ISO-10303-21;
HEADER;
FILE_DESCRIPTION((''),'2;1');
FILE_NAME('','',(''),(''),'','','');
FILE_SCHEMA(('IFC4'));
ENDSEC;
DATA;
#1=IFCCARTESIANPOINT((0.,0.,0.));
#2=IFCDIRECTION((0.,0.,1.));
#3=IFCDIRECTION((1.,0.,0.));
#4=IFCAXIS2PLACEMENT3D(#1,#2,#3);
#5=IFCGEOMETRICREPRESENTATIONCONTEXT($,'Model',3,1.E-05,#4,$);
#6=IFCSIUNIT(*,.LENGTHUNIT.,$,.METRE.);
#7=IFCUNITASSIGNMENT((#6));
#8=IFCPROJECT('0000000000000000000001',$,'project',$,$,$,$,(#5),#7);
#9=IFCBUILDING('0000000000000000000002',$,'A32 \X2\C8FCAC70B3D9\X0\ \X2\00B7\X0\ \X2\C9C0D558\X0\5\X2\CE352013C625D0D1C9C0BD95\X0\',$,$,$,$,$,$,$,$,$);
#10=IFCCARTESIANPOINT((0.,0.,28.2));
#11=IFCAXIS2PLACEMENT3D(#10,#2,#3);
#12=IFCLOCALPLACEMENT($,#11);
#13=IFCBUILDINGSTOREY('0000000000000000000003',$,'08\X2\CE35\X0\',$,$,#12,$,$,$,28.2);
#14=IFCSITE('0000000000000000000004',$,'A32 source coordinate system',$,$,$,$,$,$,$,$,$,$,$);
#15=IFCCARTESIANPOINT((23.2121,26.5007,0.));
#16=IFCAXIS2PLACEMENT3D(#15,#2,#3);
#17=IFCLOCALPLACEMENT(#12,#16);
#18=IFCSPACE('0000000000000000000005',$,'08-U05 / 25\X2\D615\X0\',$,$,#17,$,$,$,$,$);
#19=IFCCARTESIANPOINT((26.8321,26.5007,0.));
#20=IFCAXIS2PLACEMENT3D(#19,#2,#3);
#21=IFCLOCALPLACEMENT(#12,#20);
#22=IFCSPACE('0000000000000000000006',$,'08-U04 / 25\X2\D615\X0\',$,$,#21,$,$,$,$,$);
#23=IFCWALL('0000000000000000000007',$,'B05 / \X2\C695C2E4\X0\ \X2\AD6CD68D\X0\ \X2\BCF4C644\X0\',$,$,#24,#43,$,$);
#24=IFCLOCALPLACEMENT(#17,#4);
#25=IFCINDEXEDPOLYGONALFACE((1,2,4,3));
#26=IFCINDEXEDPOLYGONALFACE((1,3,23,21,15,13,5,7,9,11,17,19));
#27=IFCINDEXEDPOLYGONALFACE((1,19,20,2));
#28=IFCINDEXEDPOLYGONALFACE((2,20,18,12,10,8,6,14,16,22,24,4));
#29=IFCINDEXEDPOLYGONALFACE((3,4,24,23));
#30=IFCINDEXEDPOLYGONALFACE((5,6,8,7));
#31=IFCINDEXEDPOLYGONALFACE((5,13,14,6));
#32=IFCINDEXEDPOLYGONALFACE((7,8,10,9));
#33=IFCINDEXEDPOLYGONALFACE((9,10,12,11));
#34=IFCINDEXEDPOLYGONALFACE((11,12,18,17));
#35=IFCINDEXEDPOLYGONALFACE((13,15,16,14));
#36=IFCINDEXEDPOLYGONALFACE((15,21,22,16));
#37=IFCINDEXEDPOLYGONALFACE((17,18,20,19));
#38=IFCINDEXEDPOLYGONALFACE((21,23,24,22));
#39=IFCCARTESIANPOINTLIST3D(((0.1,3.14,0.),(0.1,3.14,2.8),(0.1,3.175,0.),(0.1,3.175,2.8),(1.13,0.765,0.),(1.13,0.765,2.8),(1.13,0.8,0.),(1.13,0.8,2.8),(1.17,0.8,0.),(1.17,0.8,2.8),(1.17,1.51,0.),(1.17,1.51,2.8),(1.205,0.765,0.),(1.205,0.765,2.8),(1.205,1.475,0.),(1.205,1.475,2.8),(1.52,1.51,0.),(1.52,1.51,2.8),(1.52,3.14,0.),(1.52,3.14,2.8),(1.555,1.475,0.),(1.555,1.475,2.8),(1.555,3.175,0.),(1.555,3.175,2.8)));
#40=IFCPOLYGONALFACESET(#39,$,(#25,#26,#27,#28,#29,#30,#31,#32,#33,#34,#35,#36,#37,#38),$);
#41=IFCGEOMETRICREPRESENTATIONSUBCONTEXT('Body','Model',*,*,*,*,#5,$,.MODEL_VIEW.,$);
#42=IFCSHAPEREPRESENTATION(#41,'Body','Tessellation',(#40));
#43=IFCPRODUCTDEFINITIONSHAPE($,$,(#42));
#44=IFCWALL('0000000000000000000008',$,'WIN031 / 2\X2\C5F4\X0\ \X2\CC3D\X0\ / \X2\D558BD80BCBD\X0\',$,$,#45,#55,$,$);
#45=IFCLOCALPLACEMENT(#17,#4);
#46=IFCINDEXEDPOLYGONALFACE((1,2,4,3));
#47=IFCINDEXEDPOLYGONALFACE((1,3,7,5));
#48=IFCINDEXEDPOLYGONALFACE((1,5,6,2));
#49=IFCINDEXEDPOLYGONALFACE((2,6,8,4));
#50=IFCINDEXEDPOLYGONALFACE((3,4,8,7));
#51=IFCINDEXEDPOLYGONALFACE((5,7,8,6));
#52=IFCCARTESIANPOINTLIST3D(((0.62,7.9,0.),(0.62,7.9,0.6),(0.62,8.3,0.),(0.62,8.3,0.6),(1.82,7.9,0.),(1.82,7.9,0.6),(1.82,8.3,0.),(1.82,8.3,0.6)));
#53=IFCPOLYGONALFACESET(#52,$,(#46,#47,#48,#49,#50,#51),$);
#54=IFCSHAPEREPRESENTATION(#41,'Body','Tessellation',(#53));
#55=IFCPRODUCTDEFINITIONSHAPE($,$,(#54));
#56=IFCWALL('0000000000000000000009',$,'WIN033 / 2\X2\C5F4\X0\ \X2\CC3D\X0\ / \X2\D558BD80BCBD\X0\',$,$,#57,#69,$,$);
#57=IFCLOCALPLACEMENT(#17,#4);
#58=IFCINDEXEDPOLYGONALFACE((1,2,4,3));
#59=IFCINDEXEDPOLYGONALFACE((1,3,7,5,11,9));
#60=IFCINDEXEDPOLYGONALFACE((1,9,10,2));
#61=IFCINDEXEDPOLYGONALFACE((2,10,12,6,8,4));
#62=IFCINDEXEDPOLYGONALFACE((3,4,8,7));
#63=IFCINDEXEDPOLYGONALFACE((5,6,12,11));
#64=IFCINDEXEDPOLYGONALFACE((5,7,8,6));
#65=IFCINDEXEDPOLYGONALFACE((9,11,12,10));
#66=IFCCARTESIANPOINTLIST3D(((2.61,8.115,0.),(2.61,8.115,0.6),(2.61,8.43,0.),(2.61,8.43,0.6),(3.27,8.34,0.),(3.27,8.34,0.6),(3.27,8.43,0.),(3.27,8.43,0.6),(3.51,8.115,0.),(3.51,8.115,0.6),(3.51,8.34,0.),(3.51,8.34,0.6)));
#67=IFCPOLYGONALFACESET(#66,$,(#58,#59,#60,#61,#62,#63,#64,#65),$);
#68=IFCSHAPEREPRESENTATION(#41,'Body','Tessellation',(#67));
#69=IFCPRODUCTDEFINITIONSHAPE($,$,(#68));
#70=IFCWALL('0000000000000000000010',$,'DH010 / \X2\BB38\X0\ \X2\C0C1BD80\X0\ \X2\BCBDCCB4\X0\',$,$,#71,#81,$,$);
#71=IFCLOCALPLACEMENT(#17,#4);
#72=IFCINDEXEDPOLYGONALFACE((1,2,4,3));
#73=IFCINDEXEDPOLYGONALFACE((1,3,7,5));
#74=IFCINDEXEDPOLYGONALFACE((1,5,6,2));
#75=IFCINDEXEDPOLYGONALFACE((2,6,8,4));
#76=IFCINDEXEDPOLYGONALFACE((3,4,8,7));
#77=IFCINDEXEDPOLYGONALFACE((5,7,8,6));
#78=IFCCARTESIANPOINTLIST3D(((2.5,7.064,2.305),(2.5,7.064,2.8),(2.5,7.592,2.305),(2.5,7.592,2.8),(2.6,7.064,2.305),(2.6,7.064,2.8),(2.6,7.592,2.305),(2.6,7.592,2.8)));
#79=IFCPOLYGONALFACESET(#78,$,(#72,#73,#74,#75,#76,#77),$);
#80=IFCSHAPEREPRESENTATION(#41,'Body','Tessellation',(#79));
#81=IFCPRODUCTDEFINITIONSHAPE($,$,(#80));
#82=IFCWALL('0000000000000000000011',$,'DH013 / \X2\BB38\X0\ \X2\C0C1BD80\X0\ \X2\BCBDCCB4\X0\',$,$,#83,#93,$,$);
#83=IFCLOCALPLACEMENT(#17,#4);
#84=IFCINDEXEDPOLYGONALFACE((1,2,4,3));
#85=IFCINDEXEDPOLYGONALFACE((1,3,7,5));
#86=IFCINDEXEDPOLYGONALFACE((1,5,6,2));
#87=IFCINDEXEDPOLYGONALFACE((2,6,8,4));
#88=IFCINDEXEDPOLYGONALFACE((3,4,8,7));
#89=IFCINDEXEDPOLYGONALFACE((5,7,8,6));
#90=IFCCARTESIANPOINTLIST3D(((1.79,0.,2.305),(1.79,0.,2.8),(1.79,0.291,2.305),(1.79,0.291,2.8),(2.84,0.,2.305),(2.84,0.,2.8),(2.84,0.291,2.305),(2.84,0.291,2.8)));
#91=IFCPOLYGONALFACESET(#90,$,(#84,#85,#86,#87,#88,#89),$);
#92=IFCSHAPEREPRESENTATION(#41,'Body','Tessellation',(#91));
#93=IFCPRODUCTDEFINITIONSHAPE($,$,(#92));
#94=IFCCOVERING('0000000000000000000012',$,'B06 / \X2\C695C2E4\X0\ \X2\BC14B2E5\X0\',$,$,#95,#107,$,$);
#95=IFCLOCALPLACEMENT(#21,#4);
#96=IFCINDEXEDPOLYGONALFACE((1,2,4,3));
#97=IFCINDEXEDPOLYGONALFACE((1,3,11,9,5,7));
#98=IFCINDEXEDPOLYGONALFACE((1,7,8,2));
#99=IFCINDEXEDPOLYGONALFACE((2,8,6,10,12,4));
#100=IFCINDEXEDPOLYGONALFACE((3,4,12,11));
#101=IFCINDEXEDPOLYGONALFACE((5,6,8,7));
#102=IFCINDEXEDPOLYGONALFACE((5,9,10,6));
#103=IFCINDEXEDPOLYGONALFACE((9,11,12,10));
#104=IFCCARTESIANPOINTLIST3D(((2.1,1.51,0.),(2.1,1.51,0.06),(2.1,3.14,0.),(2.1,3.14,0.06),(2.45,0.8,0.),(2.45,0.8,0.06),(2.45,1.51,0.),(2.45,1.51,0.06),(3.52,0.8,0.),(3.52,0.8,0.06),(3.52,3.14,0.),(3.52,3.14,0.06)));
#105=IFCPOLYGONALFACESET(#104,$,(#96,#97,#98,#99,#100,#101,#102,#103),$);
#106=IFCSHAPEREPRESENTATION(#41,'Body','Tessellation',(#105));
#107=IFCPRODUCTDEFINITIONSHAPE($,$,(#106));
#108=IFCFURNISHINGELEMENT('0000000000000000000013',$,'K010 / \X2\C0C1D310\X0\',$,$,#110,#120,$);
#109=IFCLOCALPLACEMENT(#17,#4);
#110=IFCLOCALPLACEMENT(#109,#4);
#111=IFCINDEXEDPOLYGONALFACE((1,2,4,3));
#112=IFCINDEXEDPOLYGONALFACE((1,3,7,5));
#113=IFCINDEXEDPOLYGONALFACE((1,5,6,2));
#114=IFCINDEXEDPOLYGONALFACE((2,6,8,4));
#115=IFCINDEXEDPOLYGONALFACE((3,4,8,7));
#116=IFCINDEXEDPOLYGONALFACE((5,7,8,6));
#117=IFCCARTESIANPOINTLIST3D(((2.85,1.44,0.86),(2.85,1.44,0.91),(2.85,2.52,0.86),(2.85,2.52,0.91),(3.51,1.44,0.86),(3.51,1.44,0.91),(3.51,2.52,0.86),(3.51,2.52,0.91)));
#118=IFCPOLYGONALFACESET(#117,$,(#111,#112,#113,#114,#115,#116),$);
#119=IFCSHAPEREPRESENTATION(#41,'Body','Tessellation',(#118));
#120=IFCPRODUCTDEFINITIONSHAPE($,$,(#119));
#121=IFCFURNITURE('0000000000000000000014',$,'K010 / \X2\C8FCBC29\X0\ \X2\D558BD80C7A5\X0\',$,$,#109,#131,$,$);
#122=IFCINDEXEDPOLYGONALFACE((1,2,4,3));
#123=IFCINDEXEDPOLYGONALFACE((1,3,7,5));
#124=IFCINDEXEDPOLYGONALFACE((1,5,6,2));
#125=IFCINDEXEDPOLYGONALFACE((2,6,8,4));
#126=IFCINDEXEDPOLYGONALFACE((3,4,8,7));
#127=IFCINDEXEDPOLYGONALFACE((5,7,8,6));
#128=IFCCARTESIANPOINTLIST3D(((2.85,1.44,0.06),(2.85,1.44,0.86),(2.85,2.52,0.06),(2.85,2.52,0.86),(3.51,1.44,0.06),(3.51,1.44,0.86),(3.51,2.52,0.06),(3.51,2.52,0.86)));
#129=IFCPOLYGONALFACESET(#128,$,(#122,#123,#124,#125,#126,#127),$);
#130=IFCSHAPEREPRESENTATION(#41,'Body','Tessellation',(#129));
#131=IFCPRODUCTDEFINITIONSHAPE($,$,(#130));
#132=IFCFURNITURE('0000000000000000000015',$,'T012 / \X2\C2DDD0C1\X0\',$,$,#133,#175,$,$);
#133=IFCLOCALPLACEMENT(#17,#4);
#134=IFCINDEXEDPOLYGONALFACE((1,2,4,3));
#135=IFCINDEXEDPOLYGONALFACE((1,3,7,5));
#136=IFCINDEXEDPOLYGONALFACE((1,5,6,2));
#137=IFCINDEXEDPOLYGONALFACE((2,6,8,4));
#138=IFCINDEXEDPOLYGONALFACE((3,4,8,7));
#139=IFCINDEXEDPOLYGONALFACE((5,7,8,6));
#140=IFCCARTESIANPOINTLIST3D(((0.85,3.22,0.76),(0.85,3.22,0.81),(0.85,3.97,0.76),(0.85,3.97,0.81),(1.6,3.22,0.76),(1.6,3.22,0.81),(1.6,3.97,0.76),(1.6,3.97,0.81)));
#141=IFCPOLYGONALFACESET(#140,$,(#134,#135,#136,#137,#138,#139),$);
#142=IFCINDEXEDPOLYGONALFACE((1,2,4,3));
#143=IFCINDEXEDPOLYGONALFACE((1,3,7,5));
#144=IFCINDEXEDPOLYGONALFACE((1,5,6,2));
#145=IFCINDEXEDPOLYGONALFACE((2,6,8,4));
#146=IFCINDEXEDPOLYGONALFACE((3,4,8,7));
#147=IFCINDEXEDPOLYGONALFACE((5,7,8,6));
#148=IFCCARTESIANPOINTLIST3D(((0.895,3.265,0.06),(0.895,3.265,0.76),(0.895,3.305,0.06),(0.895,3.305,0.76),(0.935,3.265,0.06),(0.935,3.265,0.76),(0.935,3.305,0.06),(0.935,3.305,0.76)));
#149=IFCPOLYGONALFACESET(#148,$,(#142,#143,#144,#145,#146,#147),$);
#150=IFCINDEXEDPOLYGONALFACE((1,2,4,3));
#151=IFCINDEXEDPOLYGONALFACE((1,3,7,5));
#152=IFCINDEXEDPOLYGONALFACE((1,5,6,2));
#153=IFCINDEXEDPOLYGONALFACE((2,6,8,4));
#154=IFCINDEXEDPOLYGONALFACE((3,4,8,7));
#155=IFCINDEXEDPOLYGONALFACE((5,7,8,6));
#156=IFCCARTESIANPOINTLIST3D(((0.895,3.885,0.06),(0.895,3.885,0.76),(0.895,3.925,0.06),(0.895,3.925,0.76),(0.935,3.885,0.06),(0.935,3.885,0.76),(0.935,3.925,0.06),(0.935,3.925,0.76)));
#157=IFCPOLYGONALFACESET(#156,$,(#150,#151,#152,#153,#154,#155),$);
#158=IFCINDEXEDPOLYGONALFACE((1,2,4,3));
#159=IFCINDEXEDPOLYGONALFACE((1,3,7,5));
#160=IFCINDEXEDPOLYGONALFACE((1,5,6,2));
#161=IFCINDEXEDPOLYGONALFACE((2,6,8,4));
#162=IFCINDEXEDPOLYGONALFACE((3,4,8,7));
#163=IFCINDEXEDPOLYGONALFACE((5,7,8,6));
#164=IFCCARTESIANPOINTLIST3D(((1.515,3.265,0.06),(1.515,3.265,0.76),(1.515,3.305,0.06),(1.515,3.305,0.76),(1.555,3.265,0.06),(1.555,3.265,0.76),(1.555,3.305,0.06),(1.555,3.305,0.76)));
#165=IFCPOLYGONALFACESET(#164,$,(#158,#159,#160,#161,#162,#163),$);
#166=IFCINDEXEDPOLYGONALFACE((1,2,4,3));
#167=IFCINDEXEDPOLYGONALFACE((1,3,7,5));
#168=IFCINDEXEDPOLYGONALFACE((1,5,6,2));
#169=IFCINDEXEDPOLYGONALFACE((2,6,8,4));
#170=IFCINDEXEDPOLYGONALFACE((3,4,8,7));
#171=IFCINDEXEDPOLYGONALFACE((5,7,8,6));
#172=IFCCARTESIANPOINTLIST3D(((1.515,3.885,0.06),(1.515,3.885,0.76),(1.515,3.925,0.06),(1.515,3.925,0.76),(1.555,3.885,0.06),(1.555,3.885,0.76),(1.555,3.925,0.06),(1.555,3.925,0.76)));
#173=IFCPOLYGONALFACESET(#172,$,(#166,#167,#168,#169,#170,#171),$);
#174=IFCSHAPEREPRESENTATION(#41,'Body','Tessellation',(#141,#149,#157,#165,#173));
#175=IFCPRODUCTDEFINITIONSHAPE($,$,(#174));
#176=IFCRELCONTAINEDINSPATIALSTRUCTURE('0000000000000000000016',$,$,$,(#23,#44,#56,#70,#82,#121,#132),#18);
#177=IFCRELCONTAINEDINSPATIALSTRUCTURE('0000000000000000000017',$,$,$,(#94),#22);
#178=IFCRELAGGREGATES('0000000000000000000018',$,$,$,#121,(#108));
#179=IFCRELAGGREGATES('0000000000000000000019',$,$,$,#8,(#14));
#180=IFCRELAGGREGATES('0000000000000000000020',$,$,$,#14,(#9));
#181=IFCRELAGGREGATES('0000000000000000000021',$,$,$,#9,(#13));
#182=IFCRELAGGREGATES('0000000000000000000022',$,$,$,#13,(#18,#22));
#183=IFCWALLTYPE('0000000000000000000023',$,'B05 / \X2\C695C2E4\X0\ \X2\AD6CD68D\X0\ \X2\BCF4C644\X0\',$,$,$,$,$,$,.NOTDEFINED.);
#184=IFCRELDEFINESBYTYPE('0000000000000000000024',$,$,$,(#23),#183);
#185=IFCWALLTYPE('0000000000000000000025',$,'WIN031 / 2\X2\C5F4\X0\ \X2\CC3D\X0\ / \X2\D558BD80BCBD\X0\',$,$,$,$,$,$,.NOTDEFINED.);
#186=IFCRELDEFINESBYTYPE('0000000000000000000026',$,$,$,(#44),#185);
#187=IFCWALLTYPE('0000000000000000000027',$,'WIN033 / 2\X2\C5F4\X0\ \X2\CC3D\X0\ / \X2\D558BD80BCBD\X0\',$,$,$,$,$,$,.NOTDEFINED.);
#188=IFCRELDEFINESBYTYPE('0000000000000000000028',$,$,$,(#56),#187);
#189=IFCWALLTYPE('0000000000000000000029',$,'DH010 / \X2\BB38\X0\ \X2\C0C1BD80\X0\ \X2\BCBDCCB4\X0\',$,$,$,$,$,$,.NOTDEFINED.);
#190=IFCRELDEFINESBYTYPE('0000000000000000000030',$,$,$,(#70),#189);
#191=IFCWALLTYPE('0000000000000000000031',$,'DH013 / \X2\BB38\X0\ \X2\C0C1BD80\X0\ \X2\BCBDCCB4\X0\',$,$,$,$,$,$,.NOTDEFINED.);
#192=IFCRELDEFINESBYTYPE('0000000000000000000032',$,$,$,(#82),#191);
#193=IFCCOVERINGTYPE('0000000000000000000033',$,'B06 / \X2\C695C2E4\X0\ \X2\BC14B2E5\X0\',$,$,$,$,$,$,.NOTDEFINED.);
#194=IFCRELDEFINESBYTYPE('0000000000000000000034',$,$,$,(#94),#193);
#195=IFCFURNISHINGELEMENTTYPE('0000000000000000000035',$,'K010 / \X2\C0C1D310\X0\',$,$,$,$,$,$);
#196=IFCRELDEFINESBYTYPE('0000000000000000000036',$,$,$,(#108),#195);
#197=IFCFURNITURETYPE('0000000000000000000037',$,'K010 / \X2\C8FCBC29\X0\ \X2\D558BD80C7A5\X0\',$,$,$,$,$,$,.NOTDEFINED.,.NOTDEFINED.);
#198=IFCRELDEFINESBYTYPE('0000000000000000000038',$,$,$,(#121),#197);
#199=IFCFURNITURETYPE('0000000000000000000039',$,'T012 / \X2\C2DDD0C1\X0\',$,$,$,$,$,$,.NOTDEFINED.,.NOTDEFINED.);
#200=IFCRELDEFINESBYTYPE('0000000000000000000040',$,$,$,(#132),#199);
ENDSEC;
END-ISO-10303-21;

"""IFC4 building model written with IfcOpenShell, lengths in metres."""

from ifc_helpers import new_model, si_unit, frame, origin, origin_with_axes, place, context, subcontext, project, spatial, polyline, outline, extrude, source, transform, mapped, type_object, type_shapes, element, aggregate, save


model = new_model("IFC4")

# Units and contexts
model_context = context("Model", 3, precision=1e-05, world=origin_with_axes())
body_context = subcontext(model_context, "Body", "Model", "MODEL_VIEW")
ifc_project = project(units=[si_unit("LENGTHUNIT", "METRE")], contexts=[model_context])

# Site, building, storey, space
site = spatial("IfcSite", under=ifc_project, Name="A32 source coordinate system")
building = spatial("IfcBuilding", under=site, Name="A32 주거동 · 지하5층–옥탑지붕")
storey_placement = place(None, frame((0.0, 0.0, 28.2), z_axis=(0.0, 0.0, 1.0), x_axis=(1.0, 0.0, 0.0)))
storey = spatial("IfcBuildingStorey", under=building, at=storey_placement, Name="08층", Elevation=28.2)
space_1_placement = place(storey_placement, frame((23.2121, 26.5007, 0.0), z_axis=(0.0, 0.0, 1.0), x_axis=(1.0, 0.0, 0.0)))
space_1 = spatial("IfcSpace", under=storey, at=space_1_placement, Name="08-U05 / 25형")

# Walls
wall_type_1 = type_object("IfcWallType", Name="B05 / 욕실 구획 보완", PredefinedType="NOTDEFINED")
shared_shape_1 = source(origin(), body_context, "Body", "SweptSolid", [
    extrude(outline(polyline([(1.17, 1.51), (1.52, 1.51), (1.52, 3.14), (0.1, 3.14), (0.1, 3.175), (1.555, 3.175), (1.555, 1.475), (1.205, 1.475), (1.205, 0.765), (1.13, 0.765), (1.13, 0.8), (1.17, 0.8), (1.17, 1.51)])), origin(), (0.0, 0.0, 1.0), 2.8),
])
type_shapes(wall_type_1, [shared_shape_1])
wall_1_placement = place(space_1_placement, origin_with_axes())
element("IfcWall", 1, at=wall_1_placement, inside=space_1, type_object=wall_type_1, Name="B05 / 욕실 구획 보완", context=body_context, shape_type="MappedRepresentation", body=[
    mapped(shared_shape_1, transform((0.0, 0.0, 0.0), scale=1.0)),
])
wall_type_2 = type_object("IfcWallType", Name="WIN031 / 2열 창 / 하부벽", PredefinedType="NOTDEFINED")
shared_shape_2 = source(origin(), body_context, "Body", "SweptSolid", [
    extrude(outline(polyline([(0.62, 8.3), (1.82, 8.3), (1.82, 7.9), (0.62, 7.9), (0.62, 8.3)])), origin(), (0.0, 0.0, 1.0), 0.6),
])
type_shapes(wall_type_2, [shared_shape_2])
wall_2_placement = place(space_1_placement, origin_with_axes())
element("IfcWall", 2, at=wall_2_placement, inside=space_1, type_object=wall_type_2, Name="WIN031 / 2열 창 / 하부벽", context=body_context, shape_type="MappedRepresentation", body=[
    mapped(shared_shape_2, transform((0.0, 0.0, 0.0), scale=1.0)),
])
wall_type_3 = type_object("IfcWallType", Name="WIN033 / 2열 창 / 하부벽", PredefinedType="NOTDEFINED")
shared_shape_3 = source(origin(), body_context, "Body", "SweptSolid", [
    extrude(outline(polyline([(2.61, 8.43), (3.27, 8.43), (3.27, 8.34), (3.51, 8.34), (3.51, 8.115), (2.61, 8.115), (2.61, 8.43)])), origin(), (0.0, 0.0, 1.0), 0.6),
])
type_shapes(wall_type_3, [shared_shape_3])
wall_3_placement = place(space_1_placement, origin_with_axes())
element("IfcWall", 3, at=wall_3_placement, inside=space_1, type_object=wall_type_3, Name="WIN033 / 2열 창 / 하부벽", context=body_context, shape_type="MappedRepresentation", body=[
    mapped(shared_shape_3, transform((0.0, 0.0, 0.0), scale=1.0)),
])
wall_type_4 = type_object("IfcWallType", Name="DH010 / 문 상부 벽체", PredefinedType="NOTDEFINED")
shared_shape_4 = source(origin(), body_context, "Body", "SweptSolid", [
    extrude(outline(polyline([(2.5, 7.592), (2.6, 7.592), (2.6, 7.064), (2.5, 7.064), (2.5, 7.592)])), frame((0.0, 0.0, 2.305)), (0.0, 0.0, 1.0), 0.495),
])
type_shapes(wall_type_4, [shared_shape_4])
wall_4_placement = place(space_1_placement, origin_with_axes())
element("IfcWall", 4, at=wall_4_placement, inside=space_1, type_object=wall_type_4, Name="DH010 / 문 상부 벽체", context=body_context, shape_type="MappedRepresentation", body=[
    mapped(shared_shape_4, transform((0.0, 0.0, 0.0), scale=1.0)),
])
wall_type_5 = type_object("IfcWallType", Name="DH013 / 문 상부 벽체", PredefinedType="NOTDEFINED")
shared_shape_5 = source(origin(), body_context, "Body", "SweptSolid", [
    extrude(outline(polyline([(2.84, 0.291), (2.84, 0.0), (1.79, 0.0), (1.79, 0.291), (2.84, 0.291)])), frame((0.0, 0.0, 2.305)), (0.0, 0.0, 1.0), 0.495),
])
type_shapes(wall_type_5, [shared_shape_5])
wall_5_placement = place(space_1_placement, origin_with_axes())
element("IfcWall", 5, at=wall_5_placement, inside=space_1, type_object=wall_type_5, Name="DH013 / 문 상부 벽체", context=body_context, shape_type="MappedRepresentation", body=[
    mapped(shared_shape_5, transform((0.0, 0.0, 0.0), scale=1.0)),
])

# Shared definitions
space_2_placement = place(storey_placement, frame((26.8321, 26.5007, 0.0), z_axis=(0.0, 0.0, 1.0), x_axis=(1.0, 0.0, 0.0)))
space_2 = spatial("IfcSpace", under=storey, at=space_2_placement, Name="08-U04 / 25형")

# Covering
covering_type = type_object("IfcCoveringType", Name="B06 / 욕실 바닥", PredefinedType="NOTDEFINED")
shared_shape_6 = source(origin(), body_context, "Body", "SweptSolid", [
    extrude(outline(polyline([(2.1, 3.14), (3.52, 3.14), (3.52, 0.8), (2.45, 0.8), (2.45, 1.51), (2.1, 1.51), (2.1, 3.14)])), origin(), (0.0, 0.0, 1.0), 0.06),
])
type_shapes(covering_type, [shared_shape_6])
covering_placement = place(space_2_placement, origin_with_axes())
element("IfcCovering", 6, at=covering_placement, inside=space_2, type_object=covering_type, Name="B06 / 욕실 바닥", context=body_context, shape_type="MappedRepresentation", body=[
    mapped(shared_shape_6, transform((0.0, 0.0, 0.0), scale=1.0)),
])

# Furnishing element
furnishing_element_type_1 = type_object("IfcFurnishingElementType", Name="K010 / 상판")
shared_shape_7 = source(origin(), body_context, "Body", "SweptSolid", [
    extrude(outline(polyline([(2.85, 2.52), (3.51, 2.52), (3.51, 1.44), (2.85, 1.44), (2.85, 2.52)])), frame((0.0, 0.0, 0.86)), (0.0, 0.0, 1.0), 0.05),
])
type_shapes(furnishing_element_type_1, [shared_shape_7])
furniture_1_placement = place(space_1_placement, origin_with_axes())
furnishing_1_placement = place(furniture_1_placement, origin_with_axes())
furnishing_1 = element("IfcFurnishingElement", 7, at=furnishing_1_placement, type_object=furnishing_element_type_1, Name="K010 / 상판", context=body_context, shape_type="MappedRepresentation", body=[
    mapped(shared_shape_7, transform((0.0, 0.0, 0.0), scale=1.0)),
])

# Furniture
furniture_type_1 = type_object("IfcFurnitureType", Name="K010 / 주방 하부장", AssemblyPlace="NOTDEFINED", PredefinedType="NOTDEFINED")
shared_shape_8 = source(origin(), body_context, "Body", "SweptSolid", [
    extrude(outline(polyline([(2.85, 1.44), (2.85, 2.52), (3.51, 2.52), (3.51, 1.44), (2.85, 1.44)])), frame((0.0, 0.0, 0.06)), (0.0, 0.0, 1.0), 0.8),
])
type_shapes(furniture_type_1, [shared_shape_8])
furniture_1 = element("IfcFurniture", 8, at=furniture_1_placement, inside=space_1, type_object=furniture_type_1, Name="K010 / 주방 하부장", context=body_context, shape_type="MappedRepresentation", body=[
    mapped(shared_shape_8, transform((0.0, 0.0, 0.0), scale=1.0)),
])
aggregate(furniture_1, [furnishing_1])
furniture_type_2 = type_object("IfcFurnitureType", Name="T012 / 식탁", AssemblyPlace="NOTDEFINED", PredefinedType="NOTDEFINED")
shared_shape_9 = source(origin(), body_context, "Body", "SweptSolid", [
    extrude(outline(polyline([(1.6, 3.97), (1.6, 3.22), (0.85, 3.22), (0.85, 3.97), (1.6, 3.97)])), frame((0.0, 0.0, 0.76)), (0.0, 0.0, 1.0), 0.05),
    extrude(outline(polyline([(0.895, 3.265), (0.895, 3.305), (0.935, 3.305), (0.935, 3.265), (0.895, 3.265)])), frame((0.0, 0.0, 0.06)), (0.0, 0.0, 1.0), 0.7),
    extrude(outline(polyline([(0.895, 3.885), (0.895, 3.925), (0.935, 3.925), (0.935, 3.885), (0.895, 3.885)])), frame((0.0, 0.0, 0.06)), (0.0, 0.0, 1.0), 0.7),
    extrude(outline(polyline([(1.515, 3.265), (1.515, 3.305), (1.555, 3.305), (1.555, 3.265), (1.515, 3.265)])), frame((0.0, 0.0, 0.06)), (0.0, 0.0, 1.0), 0.7),
    extrude(outline(polyline([(1.515, 3.885), (1.515, 3.925), (1.555, 3.925), (1.555, 3.885), (1.515, 3.885)])), frame((0.0, 0.0, 0.06)), (0.0, 0.0, 1.0), 0.7),
])
type_shapes(furniture_type_2, [shared_shape_9])
furniture_2_placement = place(space_1_placement, origin_with_axes())
element("IfcFurniture", 9, at=furniture_2_placement, inside=space_1, type_object=furniture_type_2, Name="T012 / 식탁", context=body_context, shape_type="MappedRepresentation", body=[
    mapped(shared_shape_9, transform((0.0, 0.0, 0.0), scale=1.0)),
])

save(model, "model.ifc")
